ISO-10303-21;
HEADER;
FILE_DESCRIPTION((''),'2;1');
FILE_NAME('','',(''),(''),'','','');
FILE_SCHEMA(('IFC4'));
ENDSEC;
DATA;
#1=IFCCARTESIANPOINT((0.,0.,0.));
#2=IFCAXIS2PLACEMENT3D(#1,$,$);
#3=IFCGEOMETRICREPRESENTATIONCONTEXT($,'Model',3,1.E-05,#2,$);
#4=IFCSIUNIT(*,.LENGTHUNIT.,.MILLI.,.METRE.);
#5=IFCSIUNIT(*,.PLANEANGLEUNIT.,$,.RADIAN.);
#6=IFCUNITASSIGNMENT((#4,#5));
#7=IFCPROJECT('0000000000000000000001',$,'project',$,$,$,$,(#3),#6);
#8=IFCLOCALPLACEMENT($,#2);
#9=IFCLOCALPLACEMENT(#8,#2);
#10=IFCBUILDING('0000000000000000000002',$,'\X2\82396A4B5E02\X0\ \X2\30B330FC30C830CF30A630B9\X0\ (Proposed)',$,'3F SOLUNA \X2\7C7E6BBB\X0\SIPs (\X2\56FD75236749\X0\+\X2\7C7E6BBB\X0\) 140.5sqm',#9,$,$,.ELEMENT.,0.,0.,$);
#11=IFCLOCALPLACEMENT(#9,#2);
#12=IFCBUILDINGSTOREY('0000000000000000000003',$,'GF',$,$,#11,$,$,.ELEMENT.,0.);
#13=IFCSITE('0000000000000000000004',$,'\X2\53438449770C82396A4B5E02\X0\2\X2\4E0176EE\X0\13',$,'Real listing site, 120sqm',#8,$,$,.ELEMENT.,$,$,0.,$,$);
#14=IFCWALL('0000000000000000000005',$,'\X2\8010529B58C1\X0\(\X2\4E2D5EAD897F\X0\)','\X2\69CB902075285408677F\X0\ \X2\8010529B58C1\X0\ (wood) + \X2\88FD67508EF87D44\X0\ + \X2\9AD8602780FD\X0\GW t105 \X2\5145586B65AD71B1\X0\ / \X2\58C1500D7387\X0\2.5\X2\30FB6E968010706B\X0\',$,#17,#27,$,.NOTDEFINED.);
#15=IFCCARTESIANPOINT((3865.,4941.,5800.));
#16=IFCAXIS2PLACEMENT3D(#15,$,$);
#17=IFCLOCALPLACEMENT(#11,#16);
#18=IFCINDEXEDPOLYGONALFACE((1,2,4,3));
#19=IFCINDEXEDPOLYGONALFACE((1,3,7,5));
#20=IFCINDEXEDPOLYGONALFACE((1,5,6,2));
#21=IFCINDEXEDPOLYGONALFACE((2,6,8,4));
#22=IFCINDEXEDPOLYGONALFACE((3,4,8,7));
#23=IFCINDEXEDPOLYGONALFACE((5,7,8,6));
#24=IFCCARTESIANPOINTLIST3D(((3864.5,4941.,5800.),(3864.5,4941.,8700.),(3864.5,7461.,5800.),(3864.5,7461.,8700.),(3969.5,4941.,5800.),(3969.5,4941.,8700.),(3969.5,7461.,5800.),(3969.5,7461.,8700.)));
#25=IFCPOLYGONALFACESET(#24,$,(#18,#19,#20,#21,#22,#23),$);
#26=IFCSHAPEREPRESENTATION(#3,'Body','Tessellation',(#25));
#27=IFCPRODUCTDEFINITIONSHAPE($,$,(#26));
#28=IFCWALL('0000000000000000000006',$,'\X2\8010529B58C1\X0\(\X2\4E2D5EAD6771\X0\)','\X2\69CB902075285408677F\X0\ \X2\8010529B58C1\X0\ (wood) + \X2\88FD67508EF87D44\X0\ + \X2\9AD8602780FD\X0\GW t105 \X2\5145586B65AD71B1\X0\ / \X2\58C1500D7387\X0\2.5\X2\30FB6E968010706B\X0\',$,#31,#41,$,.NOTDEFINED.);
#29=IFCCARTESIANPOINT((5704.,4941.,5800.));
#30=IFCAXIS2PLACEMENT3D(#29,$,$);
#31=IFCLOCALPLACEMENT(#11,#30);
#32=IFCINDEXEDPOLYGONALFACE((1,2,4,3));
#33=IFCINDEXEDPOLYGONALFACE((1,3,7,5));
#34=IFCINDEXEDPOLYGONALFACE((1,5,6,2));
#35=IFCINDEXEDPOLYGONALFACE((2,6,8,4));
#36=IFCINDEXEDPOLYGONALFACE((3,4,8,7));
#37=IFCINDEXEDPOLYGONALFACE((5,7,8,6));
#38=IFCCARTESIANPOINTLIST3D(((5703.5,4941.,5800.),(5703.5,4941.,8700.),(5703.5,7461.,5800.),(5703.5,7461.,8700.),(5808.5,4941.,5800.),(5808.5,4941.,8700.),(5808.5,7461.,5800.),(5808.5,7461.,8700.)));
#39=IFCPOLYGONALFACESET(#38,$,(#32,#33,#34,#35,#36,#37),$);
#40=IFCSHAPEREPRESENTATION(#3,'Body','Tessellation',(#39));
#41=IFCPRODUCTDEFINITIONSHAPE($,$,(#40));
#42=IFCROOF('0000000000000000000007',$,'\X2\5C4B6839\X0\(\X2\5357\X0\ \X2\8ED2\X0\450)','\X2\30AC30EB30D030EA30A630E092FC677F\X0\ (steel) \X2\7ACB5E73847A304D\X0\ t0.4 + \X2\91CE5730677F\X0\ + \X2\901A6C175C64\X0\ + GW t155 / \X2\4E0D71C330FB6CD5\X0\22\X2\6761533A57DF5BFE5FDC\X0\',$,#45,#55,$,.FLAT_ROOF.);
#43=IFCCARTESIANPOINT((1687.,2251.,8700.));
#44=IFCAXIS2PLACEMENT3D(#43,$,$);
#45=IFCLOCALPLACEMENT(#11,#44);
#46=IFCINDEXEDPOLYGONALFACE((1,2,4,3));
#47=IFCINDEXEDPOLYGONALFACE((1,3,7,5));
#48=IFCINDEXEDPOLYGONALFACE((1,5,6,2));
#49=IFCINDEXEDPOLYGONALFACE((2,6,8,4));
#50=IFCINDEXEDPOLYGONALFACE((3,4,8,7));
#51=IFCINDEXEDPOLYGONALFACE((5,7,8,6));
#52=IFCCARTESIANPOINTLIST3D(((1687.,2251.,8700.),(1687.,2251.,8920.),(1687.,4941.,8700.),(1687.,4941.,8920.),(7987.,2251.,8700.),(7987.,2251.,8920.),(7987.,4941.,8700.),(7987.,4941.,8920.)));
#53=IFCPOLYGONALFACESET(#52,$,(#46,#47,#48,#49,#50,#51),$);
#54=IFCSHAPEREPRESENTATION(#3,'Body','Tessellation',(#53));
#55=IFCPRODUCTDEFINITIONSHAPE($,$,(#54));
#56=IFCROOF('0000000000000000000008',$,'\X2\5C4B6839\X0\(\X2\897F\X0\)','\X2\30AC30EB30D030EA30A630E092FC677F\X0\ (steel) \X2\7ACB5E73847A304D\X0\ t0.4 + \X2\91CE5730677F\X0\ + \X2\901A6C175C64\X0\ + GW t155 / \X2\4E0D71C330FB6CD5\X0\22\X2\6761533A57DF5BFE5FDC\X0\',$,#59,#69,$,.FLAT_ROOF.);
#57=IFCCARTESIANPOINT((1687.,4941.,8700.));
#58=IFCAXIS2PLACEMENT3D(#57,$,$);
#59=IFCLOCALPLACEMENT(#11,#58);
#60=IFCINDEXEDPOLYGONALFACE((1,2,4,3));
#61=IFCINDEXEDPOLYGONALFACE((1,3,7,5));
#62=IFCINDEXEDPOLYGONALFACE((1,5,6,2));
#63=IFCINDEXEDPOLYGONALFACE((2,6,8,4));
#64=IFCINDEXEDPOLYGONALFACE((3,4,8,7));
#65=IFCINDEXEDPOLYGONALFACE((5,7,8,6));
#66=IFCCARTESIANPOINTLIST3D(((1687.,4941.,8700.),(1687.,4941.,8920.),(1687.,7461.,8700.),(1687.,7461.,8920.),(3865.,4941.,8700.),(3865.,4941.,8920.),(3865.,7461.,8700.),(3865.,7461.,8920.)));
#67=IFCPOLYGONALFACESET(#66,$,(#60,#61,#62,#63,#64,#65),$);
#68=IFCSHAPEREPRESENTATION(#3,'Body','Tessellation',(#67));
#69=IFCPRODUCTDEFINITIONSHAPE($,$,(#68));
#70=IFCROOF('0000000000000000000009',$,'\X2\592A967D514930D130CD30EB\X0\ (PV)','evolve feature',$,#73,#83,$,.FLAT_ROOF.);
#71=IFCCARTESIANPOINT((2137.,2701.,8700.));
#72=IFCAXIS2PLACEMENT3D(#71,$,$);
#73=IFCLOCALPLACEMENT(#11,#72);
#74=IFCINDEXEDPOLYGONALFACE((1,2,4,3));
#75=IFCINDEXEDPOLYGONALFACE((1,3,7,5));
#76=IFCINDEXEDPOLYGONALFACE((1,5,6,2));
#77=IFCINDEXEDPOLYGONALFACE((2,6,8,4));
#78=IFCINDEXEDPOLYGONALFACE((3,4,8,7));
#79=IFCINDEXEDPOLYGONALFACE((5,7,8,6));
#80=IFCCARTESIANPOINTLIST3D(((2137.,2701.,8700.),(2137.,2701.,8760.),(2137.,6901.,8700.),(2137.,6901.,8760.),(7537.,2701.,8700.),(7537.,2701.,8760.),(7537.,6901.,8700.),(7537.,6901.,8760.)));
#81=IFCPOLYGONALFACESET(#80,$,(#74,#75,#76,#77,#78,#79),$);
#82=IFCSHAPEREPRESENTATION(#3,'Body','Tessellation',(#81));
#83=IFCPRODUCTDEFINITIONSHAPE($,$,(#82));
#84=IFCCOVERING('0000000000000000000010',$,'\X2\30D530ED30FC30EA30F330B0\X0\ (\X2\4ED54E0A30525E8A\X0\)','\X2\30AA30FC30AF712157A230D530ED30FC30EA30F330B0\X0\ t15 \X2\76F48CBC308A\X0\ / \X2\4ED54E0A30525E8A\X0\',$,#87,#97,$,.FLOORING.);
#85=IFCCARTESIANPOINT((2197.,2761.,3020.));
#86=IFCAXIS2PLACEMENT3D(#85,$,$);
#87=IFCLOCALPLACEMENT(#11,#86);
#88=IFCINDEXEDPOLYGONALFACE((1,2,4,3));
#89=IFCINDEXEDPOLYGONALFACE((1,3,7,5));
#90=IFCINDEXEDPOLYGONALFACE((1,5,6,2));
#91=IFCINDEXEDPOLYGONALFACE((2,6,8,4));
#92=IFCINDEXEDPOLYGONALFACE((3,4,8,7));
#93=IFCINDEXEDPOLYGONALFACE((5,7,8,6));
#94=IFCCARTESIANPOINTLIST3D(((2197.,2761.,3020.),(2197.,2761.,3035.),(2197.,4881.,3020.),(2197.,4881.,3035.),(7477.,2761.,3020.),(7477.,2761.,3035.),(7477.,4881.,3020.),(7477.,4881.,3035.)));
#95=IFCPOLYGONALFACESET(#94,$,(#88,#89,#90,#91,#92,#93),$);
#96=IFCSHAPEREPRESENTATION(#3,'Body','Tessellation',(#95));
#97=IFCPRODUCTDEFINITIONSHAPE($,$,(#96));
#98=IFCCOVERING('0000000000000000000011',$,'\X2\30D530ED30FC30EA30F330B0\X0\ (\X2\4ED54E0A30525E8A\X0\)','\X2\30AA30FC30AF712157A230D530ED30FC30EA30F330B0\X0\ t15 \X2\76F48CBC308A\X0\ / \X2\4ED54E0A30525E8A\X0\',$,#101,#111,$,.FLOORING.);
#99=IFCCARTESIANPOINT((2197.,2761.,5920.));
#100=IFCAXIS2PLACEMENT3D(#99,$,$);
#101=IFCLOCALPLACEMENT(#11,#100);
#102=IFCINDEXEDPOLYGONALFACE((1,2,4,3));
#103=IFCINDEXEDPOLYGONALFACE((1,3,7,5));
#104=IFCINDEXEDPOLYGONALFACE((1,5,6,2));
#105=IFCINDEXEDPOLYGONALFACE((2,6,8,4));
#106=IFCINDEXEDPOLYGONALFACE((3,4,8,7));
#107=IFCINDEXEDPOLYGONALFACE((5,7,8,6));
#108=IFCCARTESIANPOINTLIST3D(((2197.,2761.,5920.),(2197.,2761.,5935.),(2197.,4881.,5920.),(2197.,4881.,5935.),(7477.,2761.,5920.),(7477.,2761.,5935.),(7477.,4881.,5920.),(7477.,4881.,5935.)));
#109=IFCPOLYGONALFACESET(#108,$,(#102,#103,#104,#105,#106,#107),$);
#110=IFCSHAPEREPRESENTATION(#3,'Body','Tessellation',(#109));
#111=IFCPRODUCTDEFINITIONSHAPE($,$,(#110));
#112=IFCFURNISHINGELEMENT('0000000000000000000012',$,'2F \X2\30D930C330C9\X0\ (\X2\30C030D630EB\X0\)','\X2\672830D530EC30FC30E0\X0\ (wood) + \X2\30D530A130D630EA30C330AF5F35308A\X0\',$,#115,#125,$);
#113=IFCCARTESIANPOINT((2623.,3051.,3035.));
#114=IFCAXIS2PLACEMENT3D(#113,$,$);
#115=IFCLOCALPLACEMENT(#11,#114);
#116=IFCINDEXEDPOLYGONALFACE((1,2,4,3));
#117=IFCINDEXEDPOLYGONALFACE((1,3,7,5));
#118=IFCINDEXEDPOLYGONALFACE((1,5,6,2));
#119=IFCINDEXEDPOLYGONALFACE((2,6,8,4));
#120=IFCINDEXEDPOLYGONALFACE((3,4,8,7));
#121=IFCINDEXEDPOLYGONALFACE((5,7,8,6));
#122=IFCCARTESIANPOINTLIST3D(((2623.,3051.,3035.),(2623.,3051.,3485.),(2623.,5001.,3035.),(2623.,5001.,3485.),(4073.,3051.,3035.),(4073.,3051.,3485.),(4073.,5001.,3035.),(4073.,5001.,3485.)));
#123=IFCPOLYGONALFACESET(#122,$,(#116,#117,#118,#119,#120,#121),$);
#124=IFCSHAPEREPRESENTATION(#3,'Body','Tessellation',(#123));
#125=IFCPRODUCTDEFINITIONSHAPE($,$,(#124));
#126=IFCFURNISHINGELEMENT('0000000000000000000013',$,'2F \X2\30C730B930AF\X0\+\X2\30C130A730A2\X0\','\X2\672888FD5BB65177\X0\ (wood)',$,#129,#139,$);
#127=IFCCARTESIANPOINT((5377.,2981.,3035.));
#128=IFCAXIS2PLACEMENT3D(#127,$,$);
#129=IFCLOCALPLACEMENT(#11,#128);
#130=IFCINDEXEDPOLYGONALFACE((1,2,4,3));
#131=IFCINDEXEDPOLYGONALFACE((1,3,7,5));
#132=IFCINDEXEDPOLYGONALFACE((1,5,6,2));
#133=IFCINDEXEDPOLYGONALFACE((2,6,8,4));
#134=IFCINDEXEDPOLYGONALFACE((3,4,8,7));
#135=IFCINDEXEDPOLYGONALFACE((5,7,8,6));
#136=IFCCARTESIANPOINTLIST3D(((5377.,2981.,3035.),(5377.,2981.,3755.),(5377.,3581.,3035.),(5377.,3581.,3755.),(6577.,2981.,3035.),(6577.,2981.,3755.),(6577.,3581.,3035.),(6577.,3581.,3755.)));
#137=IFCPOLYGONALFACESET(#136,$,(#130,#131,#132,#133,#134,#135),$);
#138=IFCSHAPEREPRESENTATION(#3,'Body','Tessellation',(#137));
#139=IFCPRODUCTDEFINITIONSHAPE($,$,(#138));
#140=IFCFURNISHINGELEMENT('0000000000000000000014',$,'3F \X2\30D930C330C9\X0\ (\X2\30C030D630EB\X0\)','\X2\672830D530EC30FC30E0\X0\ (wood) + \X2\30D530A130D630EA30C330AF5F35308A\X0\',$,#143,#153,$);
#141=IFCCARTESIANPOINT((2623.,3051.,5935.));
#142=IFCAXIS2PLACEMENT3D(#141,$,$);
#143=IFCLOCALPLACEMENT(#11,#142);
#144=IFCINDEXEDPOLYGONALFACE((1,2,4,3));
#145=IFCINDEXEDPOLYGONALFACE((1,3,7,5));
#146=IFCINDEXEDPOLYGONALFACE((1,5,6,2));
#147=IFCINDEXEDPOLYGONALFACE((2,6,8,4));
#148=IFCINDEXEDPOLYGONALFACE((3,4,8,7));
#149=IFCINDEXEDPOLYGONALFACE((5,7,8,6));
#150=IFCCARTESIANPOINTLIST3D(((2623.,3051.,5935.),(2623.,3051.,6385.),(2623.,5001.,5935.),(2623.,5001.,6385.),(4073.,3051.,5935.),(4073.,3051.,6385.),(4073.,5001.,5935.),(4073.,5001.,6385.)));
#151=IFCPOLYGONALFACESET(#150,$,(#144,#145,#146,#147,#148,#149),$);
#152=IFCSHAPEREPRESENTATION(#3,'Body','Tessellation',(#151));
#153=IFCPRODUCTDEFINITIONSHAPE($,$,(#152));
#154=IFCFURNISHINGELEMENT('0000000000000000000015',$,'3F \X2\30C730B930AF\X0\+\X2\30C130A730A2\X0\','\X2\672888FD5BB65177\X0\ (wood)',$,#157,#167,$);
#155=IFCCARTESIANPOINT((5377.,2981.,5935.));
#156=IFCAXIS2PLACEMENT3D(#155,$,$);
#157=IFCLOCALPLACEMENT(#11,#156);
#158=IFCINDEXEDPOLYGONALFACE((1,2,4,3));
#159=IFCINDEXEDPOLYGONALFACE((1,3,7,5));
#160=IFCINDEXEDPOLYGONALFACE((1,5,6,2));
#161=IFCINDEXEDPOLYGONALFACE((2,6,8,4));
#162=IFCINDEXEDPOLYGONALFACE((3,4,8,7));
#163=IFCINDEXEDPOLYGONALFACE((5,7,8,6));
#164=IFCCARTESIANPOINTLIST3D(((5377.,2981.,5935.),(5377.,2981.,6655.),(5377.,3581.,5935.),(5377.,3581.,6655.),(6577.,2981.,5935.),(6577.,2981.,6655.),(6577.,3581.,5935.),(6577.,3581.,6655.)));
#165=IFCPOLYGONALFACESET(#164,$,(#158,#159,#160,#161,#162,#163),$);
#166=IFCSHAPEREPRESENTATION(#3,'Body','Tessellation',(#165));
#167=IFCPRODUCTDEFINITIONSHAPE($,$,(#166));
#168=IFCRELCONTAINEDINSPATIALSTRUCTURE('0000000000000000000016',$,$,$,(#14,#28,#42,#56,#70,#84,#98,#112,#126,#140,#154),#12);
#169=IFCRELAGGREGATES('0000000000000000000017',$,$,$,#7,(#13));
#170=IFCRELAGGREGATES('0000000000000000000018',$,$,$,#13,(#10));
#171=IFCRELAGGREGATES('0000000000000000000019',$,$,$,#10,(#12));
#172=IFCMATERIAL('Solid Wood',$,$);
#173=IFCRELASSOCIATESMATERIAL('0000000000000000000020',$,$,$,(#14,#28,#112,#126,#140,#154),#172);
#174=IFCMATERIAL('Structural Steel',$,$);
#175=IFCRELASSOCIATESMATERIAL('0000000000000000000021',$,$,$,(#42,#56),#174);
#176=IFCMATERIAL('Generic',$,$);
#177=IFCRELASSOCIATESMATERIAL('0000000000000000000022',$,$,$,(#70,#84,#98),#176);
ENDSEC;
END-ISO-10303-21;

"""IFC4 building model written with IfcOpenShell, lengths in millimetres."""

from ifc_helpers import new_model, si_unit, frame, frame_2d, origin, place, context, project, spatial, rectangle, extrude, material, element, save


model = new_model("IFC4")

# Units and contexts
model_context = context("Model", 3, precision=1e-05, world=origin())
ifc_project = project(units=[si_unit("LENGTHUNIT", "METRE", prefix="MILLI"), si_unit("PLANEANGLEUNIT", "RADIAN")], contexts=[model_context])

# Site, building, storey
site_placement = place(None, origin())
site = spatial("IfcSite", under=ifc_project, at=site_placement, Name="千葉県船橋市2丁目13", ObjectType="Real listing site, 120sqm", CompositionType="ELEMENT", RefElevation=0.0)
building_placement = place(site_placement, origin())
building = spatial("IfcBuilding", under=site, at=building_placement, Name="船橋市 コートハウス (Proposed)", ObjectType="3F SOLUNA 籾殻SIPs (国産杉+籾殻) 140.5sqm", CompositionType="ELEMENT", ElevationOfRefHeight=0.0, ElevationOfTerrain=0.0)
storey_placement = place(building_placement, origin())
storey = spatial("IfcBuildingStorey", under=building, at=storey_placement, Name="GF", CompositionType="ELEMENT", Elevation=0.0)

# Shared definitions
ifc_material_1 = material(Name="Solid Wood")

# Walls
wall_1_placement = place(storey_placement, frame((3865.0, 4941.0, 5800.0)))
element("IfcWall", 1, at=wall_1_placement, inside=storey, material=ifc_material_1, Name="耐力壁(中庭西)", Description="構造用合板 耐力壁 (wood) + 製材軸組 + 高性能GW t105 充填断熱 / 壁倍率2.5・準耐火", PredefinedType="NOTDEFINED", context=model_context, shape_type="SweptSolid", body=[
    extrude(rectangle(XDim=105.0, YDim=2520.0, at=frame_2d((52.0, 1260.0))), frame((3865.0, 4941.0, 5800.0)), (0.0, 0.0, 1.0), 2900.0),
])
wall_2_placement = place(storey_placement, frame((5704.0, 4941.0, 5800.0)))
element("IfcWall", 2, at=wall_2_placement, inside=storey, material=ifc_material_1, Name="耐力壁(中庭東)", Description="構造用合板 耐力壁 (wood) + 製材軸組 + 高性能GW t105 充填断熱 / 壁倍率2.5・準耐火", PredefinedType="NOTDEFINED", context=model_context, shape_type="SweptSolid", body=[
    extrude(rectangle(XDim=105.0, YDim=2520.0, at=frame_2d((52.0, 1260.0))), frame((5704.0, 4941.0, 5800.0)), (0.0, 0.0, 1.0), 2900.0),
])

# Roofs
ifc_material_2 = material(Name="Structural Steel")
roof_1_placement = place(storey_placement, frame((1687.0, 2251.0, 8700.0)))
element("IfcRoof", 3, at=roof_1_placement, inside=storey, material=ifc_material_2, Name="屋根(南 軒450)", Description="ガルバリウム鋼板 (steel) 立平葺き t0.4 + 野地板 + 通気層 + GW t155 / 不燃・法22条区域対応", PredefinedType="FLAT_ROOF", context=model_context, shape_type="SweptSolid", body=[
    extrude(rectangle(XDim=6300.0, YDim=2690.0, at=frame_2d((3150.0, 1345.0))), frame((1687.0, 2251.0, 8700.0)), (0.0, 0.0, 1.0), 220.0),
])
roof_2_placement = place(storey_placement, frame((1687.0, 4941.0, 8700.0)))
element("IfcRoof", 4, at=roof_2_placement, inside=storey, material=ifc_material_2, Name="屋根(西)", Description="ガルバリウム鋼板 (steel) 立平葺き t0.4 + 野地板 + 通気層 + GW t155 / 不燃・法22条区域対応", PredefinedType="FLAT_ROOF", context=model_context, shape_type="SweptSolid", body=[
    extrude(rectangle(XDim=2178.0, YDim=2520.0, at=frame_2d((1089.0, 1260.0))), frame((1687.0, 4941.0, 8700.0)), (0.0, 0.0, 1.0), 220.0),
])
ifc_material_3 = material(Name="Generic")
roof_3_placement = place(storey_placement, frame((2137.0, 2701.0, 8700.0)))
element("IfcRoof", 5, at=roof_3_placement, inside=storey, material=ifc_material_3, Name="太陽光パネル (PV)", Description="evolve feature", PredefinedType="FLAT_ROOF", context=model_context, shape_type="SweptSolid", body=[
    extrude(rectangle(XDim=5400.0, YDim=4200.0, at=frame_2d((2700.0, 2100.0))), frame((2137.0, 2701.0, 8700.0)), (0.0, 0.0, 1.0), 60.0),
])

# Coverings
covering_1_placement = place(storey_placement, frame((2197.0, 2761.0, 3020.0)))
element("IfcCovering", 6, at=covering_1_placement, inside=storey, material=ifc_material_3, Name="フローリング (仕上げ床)", Description="オーク無垢フローリング t15 直貼り / 仕上げ床", PredefinedType="FLOORING", context=model_context, shape_type="SweptSolid", body=[
    extrude(rectangle(XDim=5280.0, YDim=2120.0, at=frame_2d((2640.0, 1060.0))), frame((2197.0, 2761.0, 3020.0)), (0.0, 0.0, 1.0), 15.0),
])
covering_2_placement = place(storey_placement, frame((2197.0, 2761.0, 5920.0)))
element("IfcCovering", 7, at=covering_2_placement, inside=storey, material=ifc_material_3, Name="フローリング (仕上げ床)", Description="オーク無垢フローリング t15 直貼り / 仕上げ床", PredefinedType="FLOORING", context=model_context, shape_type="SweptSolid", body=[
    extrude(rectangle(XDim=5280.0, YDim=2120.0, at=frame_2d((2640.0, 1060.0))), frame((2197.0, 2761.0, 5920.0)), (0.0, 0.0, 1.0), 15.0),
])

# Furnishing elements
furnishing_1_placement = place(storey_placement, frame((2623.0, 3051.0, 3035.0)))
element("IfcFurnishingElement", 8, at=furnishing_1_placement, inside=storey, material=ifc_material_1, Name="2F ベッド (ダブル)", Description="木フレーム (wood) + ファブリック張り", context=model_context, shape_type="SweptSolid", body=[
    extrude(rectangle(XDim=1450.0, YDim=1950.0, at=frame_2d((725.0, 975.0))), frame((2623.0, 3051.0, 3035.0)), (0.0, 0.0, 1.0), 450.0),
])
furnishing_2_placement = place(storey_placement, frame((5377.0, 2981.0, 3035.0)))
element("IfcFurnishingElement", 9, at=furnishing_2_placement, inside=storey, material=ifc_material_1, Name="2F デスク+チェア", Description="木製家具 (wood)", context=model_context, shape_type="SweptSolid", body=[
    extrude(rectangle(XDim=1200.0, YDim=600.0, at=frame_2d((600.0, 300.0))), frame((5377.0, 2981.0, 3035.0)), (0.0, 0.0, 1.0), 720.0),
])
furnishing_3_placement = place(storey_placement, frame((2623.0, 3051.0, 5935.0)))
element("IfcFurnishingElement", 10, at=furnishing_3_placement, inside=storey, material=ifc_material_1, Name="3F ベッド (ダブル)", Description="木フレーム (wood) + ファブリック張り", context=model_context, shape_type="SweptSolid", body=[
    extrude(rectangle(XDim=1450.0, YDim=1950.0, at=frame_2d((725.0, 975.0))), frame((2623.0, 3051.0, 5935.0)), (0.0, 0.0, 1.0), 450.0),
])
furnishing_4_placement = place(storey_placement, frame((5377.0, 2981.0, 5935.0)))
element("IfcFurnishingElement", 11, at=furnishing_4_placement, inside=storey, material=ifc_material_1, Name="3F デスク+チェア", Description="木製家具 (wood)", context=model_context, shape_type="SweptSolid", body=[
    extrude(rectangle(XDim=1200.0, YDim=600.0, at=frame_2d((600.0, 300.0))), frame((5377.0, 2981.0, 5935.0)), (0.0, 0.0, 1.0), 720.0),
])

save(model, "model.ifc")
